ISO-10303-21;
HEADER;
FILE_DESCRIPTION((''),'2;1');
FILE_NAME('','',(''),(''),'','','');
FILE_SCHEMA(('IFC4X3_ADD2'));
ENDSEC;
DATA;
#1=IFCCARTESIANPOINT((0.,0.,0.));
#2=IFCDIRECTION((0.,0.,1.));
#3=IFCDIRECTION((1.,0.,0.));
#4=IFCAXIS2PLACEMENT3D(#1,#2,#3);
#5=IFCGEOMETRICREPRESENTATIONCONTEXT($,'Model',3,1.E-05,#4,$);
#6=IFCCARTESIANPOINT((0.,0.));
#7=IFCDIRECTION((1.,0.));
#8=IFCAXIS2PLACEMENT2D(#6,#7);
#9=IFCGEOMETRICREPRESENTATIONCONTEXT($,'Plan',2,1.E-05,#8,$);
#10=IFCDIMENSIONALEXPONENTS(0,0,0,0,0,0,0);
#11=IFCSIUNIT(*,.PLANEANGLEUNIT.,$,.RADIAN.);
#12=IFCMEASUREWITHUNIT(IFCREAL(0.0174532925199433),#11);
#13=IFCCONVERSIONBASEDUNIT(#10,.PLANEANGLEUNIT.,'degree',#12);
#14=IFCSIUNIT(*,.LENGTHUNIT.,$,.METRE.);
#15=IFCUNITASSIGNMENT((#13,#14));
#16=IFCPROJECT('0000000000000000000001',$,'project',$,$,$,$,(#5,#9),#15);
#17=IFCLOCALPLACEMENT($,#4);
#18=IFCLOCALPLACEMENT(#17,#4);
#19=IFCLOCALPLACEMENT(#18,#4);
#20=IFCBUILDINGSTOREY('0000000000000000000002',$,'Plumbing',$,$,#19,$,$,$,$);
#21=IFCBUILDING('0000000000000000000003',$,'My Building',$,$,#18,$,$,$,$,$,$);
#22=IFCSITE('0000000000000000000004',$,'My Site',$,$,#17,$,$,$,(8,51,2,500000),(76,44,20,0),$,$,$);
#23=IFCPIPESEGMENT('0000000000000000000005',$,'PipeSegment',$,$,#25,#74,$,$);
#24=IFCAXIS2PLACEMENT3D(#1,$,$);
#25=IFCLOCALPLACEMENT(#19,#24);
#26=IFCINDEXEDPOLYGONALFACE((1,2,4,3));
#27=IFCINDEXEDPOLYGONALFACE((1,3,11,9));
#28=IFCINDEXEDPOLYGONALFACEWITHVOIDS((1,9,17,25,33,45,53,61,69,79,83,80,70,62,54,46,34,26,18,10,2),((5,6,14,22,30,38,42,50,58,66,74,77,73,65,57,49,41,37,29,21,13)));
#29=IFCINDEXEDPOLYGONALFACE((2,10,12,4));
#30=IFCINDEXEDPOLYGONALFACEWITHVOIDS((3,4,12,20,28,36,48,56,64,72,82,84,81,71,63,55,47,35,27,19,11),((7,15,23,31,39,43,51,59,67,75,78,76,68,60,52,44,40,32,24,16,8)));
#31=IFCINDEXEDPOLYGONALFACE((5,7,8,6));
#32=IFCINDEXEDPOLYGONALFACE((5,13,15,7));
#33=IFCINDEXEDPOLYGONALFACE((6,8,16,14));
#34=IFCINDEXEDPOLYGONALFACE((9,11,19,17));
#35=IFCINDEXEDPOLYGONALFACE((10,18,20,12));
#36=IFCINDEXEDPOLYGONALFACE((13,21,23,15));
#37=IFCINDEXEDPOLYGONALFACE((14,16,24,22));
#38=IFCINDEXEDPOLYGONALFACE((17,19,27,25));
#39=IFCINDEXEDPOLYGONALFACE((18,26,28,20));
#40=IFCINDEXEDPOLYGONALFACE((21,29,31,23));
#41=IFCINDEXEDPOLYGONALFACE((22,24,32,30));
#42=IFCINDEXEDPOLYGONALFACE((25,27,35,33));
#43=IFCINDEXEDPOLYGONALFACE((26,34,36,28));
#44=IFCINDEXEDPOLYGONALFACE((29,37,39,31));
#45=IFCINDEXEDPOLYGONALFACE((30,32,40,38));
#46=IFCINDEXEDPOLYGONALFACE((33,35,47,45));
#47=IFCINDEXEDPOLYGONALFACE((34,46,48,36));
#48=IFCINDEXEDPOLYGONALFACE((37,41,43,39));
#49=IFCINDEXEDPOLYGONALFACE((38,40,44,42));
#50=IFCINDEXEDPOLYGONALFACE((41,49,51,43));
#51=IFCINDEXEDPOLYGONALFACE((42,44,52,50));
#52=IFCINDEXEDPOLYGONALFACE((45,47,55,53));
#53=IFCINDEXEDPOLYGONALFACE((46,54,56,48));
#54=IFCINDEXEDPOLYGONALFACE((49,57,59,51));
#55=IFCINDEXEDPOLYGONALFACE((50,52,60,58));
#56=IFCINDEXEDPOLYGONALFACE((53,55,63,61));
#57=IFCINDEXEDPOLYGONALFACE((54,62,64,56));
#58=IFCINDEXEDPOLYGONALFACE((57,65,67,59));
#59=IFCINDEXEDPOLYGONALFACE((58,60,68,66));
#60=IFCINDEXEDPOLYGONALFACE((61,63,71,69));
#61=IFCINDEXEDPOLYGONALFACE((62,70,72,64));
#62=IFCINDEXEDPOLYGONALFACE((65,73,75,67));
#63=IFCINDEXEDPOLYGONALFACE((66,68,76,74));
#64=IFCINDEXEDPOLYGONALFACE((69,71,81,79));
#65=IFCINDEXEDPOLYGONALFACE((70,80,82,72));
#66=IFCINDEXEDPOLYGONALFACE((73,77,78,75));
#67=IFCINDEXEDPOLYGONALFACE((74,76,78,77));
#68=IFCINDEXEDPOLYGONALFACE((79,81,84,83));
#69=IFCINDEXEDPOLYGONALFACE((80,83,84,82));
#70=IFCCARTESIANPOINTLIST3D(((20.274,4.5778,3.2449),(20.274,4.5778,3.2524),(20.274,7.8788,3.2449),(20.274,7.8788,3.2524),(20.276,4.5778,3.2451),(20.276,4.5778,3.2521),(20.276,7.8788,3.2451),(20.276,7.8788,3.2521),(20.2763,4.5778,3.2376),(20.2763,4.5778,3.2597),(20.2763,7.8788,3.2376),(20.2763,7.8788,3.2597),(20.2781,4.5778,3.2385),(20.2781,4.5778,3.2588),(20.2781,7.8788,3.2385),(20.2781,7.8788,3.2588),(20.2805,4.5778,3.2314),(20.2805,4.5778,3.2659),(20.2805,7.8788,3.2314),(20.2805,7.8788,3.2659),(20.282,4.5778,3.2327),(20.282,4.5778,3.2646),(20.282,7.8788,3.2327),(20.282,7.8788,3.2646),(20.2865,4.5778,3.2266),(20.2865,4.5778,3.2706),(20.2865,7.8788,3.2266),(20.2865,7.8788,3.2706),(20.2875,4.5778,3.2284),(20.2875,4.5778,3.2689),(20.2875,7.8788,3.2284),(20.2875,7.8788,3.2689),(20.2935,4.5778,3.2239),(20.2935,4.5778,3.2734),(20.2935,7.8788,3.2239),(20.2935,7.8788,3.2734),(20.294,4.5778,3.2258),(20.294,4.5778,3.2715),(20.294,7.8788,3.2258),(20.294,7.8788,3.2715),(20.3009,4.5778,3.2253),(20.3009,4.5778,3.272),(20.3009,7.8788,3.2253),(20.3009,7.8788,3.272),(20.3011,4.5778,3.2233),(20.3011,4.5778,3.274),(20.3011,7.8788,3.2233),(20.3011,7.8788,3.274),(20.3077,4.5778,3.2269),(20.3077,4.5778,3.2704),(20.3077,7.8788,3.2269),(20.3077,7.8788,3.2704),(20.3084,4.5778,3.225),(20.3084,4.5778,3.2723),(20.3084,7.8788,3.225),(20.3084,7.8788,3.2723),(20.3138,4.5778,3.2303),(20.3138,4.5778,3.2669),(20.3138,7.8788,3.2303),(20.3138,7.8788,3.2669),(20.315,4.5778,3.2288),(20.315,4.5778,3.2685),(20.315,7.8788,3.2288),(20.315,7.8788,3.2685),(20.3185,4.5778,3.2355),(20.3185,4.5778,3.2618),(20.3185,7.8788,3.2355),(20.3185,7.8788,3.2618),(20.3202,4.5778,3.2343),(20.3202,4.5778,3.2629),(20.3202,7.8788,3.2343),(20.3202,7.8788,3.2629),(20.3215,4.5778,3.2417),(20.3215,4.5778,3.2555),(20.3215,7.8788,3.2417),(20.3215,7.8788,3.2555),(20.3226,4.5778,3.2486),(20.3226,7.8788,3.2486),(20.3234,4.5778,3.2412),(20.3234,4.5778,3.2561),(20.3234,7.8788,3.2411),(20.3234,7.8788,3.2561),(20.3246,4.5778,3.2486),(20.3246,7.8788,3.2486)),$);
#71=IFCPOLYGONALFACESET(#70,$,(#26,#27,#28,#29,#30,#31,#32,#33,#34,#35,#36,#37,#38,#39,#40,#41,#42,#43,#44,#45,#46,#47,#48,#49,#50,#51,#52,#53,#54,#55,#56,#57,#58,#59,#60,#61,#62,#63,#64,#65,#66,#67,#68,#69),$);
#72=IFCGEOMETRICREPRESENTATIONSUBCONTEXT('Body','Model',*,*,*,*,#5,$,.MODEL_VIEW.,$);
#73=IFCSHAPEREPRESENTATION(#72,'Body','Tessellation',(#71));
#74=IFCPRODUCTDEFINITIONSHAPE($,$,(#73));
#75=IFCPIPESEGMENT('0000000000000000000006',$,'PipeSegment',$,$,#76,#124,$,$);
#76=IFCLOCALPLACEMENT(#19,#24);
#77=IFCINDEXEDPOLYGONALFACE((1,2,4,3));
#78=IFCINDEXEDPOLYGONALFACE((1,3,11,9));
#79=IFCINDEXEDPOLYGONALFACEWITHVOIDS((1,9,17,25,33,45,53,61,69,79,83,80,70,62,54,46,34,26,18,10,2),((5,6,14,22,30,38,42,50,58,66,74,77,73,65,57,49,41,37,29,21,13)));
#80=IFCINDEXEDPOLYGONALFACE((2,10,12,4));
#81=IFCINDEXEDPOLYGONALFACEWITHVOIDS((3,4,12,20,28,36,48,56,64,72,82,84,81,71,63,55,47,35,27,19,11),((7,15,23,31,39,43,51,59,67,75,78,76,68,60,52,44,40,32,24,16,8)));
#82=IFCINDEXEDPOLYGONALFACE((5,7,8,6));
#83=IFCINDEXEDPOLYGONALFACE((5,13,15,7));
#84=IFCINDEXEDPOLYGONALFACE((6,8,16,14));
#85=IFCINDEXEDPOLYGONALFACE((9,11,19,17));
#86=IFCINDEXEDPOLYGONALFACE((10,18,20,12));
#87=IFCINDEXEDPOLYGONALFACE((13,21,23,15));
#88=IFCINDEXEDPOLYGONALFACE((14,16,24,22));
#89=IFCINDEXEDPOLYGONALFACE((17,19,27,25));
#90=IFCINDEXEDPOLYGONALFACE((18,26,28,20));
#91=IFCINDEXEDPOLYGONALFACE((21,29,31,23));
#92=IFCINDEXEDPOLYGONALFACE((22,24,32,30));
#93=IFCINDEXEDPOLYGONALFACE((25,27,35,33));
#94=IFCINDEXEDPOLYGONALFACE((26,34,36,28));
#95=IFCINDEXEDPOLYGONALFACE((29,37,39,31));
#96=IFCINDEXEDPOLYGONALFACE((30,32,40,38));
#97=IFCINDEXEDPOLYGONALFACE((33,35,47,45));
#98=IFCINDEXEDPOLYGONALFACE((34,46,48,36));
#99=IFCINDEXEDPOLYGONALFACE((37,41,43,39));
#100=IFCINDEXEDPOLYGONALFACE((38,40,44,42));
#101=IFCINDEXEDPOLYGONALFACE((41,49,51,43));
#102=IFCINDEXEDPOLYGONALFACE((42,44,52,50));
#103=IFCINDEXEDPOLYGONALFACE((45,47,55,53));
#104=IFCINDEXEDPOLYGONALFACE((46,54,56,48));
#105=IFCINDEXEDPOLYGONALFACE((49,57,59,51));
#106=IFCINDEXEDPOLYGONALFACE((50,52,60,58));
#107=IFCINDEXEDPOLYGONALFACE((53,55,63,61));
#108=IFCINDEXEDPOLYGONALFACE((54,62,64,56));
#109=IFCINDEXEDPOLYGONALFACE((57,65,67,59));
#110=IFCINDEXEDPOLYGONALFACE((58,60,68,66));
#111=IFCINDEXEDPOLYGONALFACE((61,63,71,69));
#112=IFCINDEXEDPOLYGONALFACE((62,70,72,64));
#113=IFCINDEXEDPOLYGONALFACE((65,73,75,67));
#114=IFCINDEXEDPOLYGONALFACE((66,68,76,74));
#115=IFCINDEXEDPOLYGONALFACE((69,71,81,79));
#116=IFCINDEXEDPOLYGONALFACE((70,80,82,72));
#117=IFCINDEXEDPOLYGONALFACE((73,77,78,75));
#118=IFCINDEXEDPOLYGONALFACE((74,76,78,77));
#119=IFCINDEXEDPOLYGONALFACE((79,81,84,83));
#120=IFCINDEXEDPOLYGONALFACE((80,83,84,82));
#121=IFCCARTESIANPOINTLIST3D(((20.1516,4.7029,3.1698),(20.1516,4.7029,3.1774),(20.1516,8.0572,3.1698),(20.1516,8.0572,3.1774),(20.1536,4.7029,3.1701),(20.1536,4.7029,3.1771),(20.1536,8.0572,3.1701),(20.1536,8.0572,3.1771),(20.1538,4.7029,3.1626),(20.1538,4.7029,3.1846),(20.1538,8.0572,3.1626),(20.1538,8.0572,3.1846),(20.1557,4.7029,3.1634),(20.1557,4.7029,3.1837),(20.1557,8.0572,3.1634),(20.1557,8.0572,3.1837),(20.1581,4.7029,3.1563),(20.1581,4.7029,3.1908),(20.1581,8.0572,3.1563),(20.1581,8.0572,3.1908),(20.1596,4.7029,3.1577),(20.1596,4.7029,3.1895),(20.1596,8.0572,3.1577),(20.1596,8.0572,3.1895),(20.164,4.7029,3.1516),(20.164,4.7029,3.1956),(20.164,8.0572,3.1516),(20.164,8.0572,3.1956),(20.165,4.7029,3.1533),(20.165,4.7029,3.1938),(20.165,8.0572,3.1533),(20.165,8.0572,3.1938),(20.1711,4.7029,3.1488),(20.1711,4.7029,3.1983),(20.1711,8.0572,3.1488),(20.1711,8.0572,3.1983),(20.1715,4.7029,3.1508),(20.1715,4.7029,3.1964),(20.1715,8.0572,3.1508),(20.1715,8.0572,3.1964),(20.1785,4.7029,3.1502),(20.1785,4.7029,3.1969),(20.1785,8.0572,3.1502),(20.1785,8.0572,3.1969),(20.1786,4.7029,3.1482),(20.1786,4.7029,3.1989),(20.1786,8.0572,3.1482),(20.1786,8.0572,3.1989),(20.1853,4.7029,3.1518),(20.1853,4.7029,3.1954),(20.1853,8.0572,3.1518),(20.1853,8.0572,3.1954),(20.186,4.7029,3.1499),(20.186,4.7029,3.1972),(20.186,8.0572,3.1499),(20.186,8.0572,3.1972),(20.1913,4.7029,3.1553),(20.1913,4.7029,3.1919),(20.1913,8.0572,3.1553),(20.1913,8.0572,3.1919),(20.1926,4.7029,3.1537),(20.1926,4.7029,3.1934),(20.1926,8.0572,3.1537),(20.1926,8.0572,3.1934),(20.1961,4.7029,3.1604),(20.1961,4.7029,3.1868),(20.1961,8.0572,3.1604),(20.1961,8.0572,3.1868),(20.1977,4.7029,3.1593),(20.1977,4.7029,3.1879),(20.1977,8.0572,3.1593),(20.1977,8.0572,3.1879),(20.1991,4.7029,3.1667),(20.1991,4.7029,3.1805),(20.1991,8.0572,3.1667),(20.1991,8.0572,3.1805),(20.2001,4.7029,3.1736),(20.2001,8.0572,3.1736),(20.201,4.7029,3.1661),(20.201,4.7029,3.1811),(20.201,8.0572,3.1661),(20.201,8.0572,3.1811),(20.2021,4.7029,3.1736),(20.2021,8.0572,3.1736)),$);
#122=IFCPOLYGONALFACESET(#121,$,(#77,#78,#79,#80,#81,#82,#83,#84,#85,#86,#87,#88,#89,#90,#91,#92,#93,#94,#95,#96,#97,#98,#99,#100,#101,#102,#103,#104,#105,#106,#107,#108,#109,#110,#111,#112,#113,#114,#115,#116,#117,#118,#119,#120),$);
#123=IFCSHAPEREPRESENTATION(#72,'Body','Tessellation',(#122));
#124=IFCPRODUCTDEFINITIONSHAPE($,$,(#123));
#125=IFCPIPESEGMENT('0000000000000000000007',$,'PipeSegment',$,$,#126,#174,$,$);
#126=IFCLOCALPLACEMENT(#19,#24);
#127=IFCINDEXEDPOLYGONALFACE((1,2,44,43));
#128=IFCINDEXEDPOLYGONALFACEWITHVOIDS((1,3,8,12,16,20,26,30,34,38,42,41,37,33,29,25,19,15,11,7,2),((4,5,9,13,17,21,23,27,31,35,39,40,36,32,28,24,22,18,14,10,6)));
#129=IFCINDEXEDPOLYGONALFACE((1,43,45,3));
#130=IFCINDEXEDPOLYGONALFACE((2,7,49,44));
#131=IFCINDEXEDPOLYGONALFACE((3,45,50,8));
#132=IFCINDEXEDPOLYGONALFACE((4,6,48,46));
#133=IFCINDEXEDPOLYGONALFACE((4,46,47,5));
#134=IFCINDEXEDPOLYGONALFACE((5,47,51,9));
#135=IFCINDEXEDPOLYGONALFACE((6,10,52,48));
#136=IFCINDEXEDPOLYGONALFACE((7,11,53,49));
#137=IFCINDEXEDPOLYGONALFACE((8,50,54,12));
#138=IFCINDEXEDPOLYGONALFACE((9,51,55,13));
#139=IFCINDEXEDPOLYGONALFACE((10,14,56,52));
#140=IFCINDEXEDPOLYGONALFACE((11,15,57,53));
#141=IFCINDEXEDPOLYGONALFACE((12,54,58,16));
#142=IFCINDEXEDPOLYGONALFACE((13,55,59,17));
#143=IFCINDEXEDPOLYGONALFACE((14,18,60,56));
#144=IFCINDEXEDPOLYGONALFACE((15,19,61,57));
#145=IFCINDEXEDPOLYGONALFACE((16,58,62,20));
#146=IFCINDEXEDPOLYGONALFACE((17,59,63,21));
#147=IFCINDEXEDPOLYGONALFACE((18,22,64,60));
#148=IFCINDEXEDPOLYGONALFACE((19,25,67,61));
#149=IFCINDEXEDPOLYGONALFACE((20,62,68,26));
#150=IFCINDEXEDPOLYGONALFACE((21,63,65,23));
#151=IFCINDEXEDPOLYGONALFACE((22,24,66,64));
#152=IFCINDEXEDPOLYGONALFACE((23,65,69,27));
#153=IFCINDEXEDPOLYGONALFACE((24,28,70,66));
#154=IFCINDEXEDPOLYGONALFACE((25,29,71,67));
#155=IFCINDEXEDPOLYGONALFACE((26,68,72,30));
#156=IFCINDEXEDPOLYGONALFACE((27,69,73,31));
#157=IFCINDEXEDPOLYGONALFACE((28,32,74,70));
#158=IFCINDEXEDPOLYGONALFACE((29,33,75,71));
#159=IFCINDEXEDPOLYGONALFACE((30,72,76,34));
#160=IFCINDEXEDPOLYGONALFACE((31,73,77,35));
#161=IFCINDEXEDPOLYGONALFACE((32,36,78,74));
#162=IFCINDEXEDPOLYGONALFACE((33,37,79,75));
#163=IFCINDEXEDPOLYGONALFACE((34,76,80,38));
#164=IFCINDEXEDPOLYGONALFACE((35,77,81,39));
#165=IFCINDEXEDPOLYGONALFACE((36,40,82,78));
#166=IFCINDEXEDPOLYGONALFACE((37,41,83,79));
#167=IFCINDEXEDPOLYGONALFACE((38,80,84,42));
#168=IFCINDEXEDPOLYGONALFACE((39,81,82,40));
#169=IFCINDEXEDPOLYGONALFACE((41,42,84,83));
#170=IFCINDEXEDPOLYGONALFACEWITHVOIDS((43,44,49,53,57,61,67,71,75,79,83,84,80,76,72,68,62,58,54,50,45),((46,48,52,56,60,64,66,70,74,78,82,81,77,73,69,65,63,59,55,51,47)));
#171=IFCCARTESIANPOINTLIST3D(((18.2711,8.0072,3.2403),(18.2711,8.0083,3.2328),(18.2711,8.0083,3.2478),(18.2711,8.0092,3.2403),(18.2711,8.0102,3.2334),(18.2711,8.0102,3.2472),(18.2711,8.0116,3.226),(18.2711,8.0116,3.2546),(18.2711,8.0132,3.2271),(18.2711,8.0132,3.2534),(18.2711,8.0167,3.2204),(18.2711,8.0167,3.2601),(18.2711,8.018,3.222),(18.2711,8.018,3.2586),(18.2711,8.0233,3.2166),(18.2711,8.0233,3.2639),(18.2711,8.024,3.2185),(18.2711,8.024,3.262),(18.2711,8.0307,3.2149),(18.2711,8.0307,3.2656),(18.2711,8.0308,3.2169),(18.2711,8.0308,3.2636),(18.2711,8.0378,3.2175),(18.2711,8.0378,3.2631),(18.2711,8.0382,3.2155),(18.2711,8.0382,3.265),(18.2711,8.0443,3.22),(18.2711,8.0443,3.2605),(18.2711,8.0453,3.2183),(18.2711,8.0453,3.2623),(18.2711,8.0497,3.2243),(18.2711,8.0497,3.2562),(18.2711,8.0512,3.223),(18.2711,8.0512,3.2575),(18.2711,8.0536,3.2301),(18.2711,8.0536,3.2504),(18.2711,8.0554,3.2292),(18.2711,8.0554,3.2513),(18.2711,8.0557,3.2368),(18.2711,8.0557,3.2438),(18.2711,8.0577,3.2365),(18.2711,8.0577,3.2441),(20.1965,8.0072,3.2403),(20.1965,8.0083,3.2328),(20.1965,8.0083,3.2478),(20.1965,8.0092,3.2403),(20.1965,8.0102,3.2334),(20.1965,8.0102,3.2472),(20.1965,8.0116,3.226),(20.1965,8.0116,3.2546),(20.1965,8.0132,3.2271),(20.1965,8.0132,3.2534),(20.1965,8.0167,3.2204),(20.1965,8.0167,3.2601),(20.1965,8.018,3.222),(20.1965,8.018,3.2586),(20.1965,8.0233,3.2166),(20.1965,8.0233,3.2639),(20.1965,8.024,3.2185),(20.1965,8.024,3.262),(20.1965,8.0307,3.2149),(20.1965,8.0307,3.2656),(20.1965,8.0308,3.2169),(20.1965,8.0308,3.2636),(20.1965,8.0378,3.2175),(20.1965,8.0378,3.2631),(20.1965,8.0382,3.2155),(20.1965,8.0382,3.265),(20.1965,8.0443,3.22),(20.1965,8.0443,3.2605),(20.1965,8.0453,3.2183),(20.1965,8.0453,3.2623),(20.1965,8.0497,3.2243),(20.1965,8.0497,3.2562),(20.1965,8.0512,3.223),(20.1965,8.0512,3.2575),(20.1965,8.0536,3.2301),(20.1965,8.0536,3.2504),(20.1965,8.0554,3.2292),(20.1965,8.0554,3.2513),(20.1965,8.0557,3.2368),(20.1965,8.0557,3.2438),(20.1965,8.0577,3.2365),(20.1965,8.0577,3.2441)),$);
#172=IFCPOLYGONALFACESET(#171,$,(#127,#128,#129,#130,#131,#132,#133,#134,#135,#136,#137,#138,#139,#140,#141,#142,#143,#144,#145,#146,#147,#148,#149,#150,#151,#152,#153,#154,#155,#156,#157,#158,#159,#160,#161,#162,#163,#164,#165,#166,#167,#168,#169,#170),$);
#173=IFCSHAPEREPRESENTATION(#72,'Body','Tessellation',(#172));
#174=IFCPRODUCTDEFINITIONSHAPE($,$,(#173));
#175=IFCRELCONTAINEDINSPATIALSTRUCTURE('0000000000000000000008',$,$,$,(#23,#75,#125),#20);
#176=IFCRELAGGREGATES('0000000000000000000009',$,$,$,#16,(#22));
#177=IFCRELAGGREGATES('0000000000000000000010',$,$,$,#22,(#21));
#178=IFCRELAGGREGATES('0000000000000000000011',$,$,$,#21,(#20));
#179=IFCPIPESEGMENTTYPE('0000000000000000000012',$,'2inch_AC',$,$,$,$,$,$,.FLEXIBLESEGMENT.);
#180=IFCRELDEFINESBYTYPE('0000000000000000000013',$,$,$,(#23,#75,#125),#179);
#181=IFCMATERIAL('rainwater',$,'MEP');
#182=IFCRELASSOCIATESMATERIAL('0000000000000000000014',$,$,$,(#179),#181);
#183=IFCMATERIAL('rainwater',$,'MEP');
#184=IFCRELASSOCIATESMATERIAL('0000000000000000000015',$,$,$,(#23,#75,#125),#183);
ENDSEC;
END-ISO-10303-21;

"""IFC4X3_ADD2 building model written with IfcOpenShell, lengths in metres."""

from ifc_helpers import new_model, entity, si_unit, converted_unit, frame, origin_with_axes, origin_2d_with_axis, place, context, subcontext, project, spatial, hollow_circle, extrude, material, material_profile, profile_set, profile_usage, type_object, element, save


model = new_model("IFC4X3_ADD2")

# Units and contexts
model_context = context("Model", 3, precision=1e-05, world=origin_with_axes())
plan_context = context("Plan", 2, precision=1e-05, world=origin_2d_with_axis())
body_context = subcontext(model_context, "Body", "Model", "MODEL_VIEW")
ifc_project = project(units=[converted_unit("PLANEANGLEUNIT", "degree", entity("IfcReal", 0.0174532925199433), si_unit("PLANEANGLEUNIT", "RADIAN"), dimensions=[0, 0, 0, 0, 0, 0, 0]), si_unit("LENGTHUNIT", "METRE")], contexts=[model_context, plan_context])

# Site, building, storey
site_placement = place(None, origin_with_axes())
site = spatial("IfcSite", under=ifc_project, at=site_placement, Name="My Site", RefLatitude=(8, 51, 2, 500000), RefLongitude=(76, 44, 20, 0))
building_placement = place(site_placement, origin_with_axes())
building = spatial("IfcBuilding", under=site, at=building_placement, Name="My Building")
storey_placement = place(building_placement, origin_with_axes())
storey = spatial("IfcBuildingStorey", under=building, at=storey_placement, Name="Plumbing")

# Pipe segments
ifc_material_1 = material(Name="rainwater", Category="MEP")
ifc_material_2 = material(Name="rainwater", Category="MEP")
ifc_material_profile_1 = material_profile(ifc_material_2, hollow_circle(Radius=0.0254, WallThickness=0.002))
ifc_profile_set_1 = profile_set([ifc_material_profile_1], Name="water")
ifc_profile_usage_1 = profile_usage(ifc_profile_set_1, cardinal=5)
ifc_material_profile_2 = material_profile(ifc_material_1, hollow_circle(Radius=0.0254, WallThickness=0.002))
ifc_profile_set_2 = profile_set([ifc_material_profile_2], Name="water")
pipe_segment_type_1 = type_object("IfcPipeSegmentType", Name="2inch_AC", PredefinedType="FLEXIBLESEGMENT", material=ifc_profile_set_2)
pipe_segment_1_placement = place(storey_placement, frame((20.2992, 7.8788, 3.2486), z_axis=(0.0, -1.0, 0.0), x_axis=(1.0, 0.0, 0.0)))
element("IfcPipeSegment", 1, at=pipe_segment_1_placement, inside=storey, type_object=pipe_segment_type_1, material=ifc_profile_usage_1, Name="PipeSegment", context=body_context, shape_type="SweptSolid", body=[
    extrude(hollow_circle(Radius=0.0254, WallThickness=0.002), origin_with_axes(), (0.0, 0.0, 1.0), 3.3011),
])
ifc_profile_usage_2 = profile_usage(ifc_profile_set_1, cardinal=5)
pipe_segment_2_placement = place(storey_placement, frame((20.1767, 8.0572, 3.1736), z_axis=(0.0, -1.0, 0.0), x_axis=(1.0, 0.0, 0.0)))
element("IfcPipeSegment", 2, at=pipe_segment_2_placement, inside=storey, type_object=pipe_segment_type_1, material=ifc_profile_usage_2, Name="PipeSegment", context=body_context, shape_type="SweptSolid", body=[
    extrude(hollow_circle(Radius=0.0254, WallThickness=0.002), origin_with_axes(), (0.0, 0.0, 1.0), 3.3543),
])
ifc_profile_usage_3 = profile_usage(ifc_profile_set_1, cardinal=5)
pipe_segment_3_placement = place(storey_placement, frame((20.1965, 8.0326, 3.2403), z_axis=(-1.0, 0.0, 0.0), x_axis=(0.0, -1.0, 0.0)))
element("IfcPipeSegment", 3, at=pipe_segment_3_placement, inside=storey, type_object=pipe_segment_type_1, material=ifc_profile_usage_3, Name="PipeSegment", context=body_context, shape_type="SweptSolid", body=[
    extrude(hollow_circle(Radius=0.0254, WallThickness=0.002), origin_with_axes(), (0.0, 0.0, 1.0), 1.9254),
])

save(model, "model.ifc")
